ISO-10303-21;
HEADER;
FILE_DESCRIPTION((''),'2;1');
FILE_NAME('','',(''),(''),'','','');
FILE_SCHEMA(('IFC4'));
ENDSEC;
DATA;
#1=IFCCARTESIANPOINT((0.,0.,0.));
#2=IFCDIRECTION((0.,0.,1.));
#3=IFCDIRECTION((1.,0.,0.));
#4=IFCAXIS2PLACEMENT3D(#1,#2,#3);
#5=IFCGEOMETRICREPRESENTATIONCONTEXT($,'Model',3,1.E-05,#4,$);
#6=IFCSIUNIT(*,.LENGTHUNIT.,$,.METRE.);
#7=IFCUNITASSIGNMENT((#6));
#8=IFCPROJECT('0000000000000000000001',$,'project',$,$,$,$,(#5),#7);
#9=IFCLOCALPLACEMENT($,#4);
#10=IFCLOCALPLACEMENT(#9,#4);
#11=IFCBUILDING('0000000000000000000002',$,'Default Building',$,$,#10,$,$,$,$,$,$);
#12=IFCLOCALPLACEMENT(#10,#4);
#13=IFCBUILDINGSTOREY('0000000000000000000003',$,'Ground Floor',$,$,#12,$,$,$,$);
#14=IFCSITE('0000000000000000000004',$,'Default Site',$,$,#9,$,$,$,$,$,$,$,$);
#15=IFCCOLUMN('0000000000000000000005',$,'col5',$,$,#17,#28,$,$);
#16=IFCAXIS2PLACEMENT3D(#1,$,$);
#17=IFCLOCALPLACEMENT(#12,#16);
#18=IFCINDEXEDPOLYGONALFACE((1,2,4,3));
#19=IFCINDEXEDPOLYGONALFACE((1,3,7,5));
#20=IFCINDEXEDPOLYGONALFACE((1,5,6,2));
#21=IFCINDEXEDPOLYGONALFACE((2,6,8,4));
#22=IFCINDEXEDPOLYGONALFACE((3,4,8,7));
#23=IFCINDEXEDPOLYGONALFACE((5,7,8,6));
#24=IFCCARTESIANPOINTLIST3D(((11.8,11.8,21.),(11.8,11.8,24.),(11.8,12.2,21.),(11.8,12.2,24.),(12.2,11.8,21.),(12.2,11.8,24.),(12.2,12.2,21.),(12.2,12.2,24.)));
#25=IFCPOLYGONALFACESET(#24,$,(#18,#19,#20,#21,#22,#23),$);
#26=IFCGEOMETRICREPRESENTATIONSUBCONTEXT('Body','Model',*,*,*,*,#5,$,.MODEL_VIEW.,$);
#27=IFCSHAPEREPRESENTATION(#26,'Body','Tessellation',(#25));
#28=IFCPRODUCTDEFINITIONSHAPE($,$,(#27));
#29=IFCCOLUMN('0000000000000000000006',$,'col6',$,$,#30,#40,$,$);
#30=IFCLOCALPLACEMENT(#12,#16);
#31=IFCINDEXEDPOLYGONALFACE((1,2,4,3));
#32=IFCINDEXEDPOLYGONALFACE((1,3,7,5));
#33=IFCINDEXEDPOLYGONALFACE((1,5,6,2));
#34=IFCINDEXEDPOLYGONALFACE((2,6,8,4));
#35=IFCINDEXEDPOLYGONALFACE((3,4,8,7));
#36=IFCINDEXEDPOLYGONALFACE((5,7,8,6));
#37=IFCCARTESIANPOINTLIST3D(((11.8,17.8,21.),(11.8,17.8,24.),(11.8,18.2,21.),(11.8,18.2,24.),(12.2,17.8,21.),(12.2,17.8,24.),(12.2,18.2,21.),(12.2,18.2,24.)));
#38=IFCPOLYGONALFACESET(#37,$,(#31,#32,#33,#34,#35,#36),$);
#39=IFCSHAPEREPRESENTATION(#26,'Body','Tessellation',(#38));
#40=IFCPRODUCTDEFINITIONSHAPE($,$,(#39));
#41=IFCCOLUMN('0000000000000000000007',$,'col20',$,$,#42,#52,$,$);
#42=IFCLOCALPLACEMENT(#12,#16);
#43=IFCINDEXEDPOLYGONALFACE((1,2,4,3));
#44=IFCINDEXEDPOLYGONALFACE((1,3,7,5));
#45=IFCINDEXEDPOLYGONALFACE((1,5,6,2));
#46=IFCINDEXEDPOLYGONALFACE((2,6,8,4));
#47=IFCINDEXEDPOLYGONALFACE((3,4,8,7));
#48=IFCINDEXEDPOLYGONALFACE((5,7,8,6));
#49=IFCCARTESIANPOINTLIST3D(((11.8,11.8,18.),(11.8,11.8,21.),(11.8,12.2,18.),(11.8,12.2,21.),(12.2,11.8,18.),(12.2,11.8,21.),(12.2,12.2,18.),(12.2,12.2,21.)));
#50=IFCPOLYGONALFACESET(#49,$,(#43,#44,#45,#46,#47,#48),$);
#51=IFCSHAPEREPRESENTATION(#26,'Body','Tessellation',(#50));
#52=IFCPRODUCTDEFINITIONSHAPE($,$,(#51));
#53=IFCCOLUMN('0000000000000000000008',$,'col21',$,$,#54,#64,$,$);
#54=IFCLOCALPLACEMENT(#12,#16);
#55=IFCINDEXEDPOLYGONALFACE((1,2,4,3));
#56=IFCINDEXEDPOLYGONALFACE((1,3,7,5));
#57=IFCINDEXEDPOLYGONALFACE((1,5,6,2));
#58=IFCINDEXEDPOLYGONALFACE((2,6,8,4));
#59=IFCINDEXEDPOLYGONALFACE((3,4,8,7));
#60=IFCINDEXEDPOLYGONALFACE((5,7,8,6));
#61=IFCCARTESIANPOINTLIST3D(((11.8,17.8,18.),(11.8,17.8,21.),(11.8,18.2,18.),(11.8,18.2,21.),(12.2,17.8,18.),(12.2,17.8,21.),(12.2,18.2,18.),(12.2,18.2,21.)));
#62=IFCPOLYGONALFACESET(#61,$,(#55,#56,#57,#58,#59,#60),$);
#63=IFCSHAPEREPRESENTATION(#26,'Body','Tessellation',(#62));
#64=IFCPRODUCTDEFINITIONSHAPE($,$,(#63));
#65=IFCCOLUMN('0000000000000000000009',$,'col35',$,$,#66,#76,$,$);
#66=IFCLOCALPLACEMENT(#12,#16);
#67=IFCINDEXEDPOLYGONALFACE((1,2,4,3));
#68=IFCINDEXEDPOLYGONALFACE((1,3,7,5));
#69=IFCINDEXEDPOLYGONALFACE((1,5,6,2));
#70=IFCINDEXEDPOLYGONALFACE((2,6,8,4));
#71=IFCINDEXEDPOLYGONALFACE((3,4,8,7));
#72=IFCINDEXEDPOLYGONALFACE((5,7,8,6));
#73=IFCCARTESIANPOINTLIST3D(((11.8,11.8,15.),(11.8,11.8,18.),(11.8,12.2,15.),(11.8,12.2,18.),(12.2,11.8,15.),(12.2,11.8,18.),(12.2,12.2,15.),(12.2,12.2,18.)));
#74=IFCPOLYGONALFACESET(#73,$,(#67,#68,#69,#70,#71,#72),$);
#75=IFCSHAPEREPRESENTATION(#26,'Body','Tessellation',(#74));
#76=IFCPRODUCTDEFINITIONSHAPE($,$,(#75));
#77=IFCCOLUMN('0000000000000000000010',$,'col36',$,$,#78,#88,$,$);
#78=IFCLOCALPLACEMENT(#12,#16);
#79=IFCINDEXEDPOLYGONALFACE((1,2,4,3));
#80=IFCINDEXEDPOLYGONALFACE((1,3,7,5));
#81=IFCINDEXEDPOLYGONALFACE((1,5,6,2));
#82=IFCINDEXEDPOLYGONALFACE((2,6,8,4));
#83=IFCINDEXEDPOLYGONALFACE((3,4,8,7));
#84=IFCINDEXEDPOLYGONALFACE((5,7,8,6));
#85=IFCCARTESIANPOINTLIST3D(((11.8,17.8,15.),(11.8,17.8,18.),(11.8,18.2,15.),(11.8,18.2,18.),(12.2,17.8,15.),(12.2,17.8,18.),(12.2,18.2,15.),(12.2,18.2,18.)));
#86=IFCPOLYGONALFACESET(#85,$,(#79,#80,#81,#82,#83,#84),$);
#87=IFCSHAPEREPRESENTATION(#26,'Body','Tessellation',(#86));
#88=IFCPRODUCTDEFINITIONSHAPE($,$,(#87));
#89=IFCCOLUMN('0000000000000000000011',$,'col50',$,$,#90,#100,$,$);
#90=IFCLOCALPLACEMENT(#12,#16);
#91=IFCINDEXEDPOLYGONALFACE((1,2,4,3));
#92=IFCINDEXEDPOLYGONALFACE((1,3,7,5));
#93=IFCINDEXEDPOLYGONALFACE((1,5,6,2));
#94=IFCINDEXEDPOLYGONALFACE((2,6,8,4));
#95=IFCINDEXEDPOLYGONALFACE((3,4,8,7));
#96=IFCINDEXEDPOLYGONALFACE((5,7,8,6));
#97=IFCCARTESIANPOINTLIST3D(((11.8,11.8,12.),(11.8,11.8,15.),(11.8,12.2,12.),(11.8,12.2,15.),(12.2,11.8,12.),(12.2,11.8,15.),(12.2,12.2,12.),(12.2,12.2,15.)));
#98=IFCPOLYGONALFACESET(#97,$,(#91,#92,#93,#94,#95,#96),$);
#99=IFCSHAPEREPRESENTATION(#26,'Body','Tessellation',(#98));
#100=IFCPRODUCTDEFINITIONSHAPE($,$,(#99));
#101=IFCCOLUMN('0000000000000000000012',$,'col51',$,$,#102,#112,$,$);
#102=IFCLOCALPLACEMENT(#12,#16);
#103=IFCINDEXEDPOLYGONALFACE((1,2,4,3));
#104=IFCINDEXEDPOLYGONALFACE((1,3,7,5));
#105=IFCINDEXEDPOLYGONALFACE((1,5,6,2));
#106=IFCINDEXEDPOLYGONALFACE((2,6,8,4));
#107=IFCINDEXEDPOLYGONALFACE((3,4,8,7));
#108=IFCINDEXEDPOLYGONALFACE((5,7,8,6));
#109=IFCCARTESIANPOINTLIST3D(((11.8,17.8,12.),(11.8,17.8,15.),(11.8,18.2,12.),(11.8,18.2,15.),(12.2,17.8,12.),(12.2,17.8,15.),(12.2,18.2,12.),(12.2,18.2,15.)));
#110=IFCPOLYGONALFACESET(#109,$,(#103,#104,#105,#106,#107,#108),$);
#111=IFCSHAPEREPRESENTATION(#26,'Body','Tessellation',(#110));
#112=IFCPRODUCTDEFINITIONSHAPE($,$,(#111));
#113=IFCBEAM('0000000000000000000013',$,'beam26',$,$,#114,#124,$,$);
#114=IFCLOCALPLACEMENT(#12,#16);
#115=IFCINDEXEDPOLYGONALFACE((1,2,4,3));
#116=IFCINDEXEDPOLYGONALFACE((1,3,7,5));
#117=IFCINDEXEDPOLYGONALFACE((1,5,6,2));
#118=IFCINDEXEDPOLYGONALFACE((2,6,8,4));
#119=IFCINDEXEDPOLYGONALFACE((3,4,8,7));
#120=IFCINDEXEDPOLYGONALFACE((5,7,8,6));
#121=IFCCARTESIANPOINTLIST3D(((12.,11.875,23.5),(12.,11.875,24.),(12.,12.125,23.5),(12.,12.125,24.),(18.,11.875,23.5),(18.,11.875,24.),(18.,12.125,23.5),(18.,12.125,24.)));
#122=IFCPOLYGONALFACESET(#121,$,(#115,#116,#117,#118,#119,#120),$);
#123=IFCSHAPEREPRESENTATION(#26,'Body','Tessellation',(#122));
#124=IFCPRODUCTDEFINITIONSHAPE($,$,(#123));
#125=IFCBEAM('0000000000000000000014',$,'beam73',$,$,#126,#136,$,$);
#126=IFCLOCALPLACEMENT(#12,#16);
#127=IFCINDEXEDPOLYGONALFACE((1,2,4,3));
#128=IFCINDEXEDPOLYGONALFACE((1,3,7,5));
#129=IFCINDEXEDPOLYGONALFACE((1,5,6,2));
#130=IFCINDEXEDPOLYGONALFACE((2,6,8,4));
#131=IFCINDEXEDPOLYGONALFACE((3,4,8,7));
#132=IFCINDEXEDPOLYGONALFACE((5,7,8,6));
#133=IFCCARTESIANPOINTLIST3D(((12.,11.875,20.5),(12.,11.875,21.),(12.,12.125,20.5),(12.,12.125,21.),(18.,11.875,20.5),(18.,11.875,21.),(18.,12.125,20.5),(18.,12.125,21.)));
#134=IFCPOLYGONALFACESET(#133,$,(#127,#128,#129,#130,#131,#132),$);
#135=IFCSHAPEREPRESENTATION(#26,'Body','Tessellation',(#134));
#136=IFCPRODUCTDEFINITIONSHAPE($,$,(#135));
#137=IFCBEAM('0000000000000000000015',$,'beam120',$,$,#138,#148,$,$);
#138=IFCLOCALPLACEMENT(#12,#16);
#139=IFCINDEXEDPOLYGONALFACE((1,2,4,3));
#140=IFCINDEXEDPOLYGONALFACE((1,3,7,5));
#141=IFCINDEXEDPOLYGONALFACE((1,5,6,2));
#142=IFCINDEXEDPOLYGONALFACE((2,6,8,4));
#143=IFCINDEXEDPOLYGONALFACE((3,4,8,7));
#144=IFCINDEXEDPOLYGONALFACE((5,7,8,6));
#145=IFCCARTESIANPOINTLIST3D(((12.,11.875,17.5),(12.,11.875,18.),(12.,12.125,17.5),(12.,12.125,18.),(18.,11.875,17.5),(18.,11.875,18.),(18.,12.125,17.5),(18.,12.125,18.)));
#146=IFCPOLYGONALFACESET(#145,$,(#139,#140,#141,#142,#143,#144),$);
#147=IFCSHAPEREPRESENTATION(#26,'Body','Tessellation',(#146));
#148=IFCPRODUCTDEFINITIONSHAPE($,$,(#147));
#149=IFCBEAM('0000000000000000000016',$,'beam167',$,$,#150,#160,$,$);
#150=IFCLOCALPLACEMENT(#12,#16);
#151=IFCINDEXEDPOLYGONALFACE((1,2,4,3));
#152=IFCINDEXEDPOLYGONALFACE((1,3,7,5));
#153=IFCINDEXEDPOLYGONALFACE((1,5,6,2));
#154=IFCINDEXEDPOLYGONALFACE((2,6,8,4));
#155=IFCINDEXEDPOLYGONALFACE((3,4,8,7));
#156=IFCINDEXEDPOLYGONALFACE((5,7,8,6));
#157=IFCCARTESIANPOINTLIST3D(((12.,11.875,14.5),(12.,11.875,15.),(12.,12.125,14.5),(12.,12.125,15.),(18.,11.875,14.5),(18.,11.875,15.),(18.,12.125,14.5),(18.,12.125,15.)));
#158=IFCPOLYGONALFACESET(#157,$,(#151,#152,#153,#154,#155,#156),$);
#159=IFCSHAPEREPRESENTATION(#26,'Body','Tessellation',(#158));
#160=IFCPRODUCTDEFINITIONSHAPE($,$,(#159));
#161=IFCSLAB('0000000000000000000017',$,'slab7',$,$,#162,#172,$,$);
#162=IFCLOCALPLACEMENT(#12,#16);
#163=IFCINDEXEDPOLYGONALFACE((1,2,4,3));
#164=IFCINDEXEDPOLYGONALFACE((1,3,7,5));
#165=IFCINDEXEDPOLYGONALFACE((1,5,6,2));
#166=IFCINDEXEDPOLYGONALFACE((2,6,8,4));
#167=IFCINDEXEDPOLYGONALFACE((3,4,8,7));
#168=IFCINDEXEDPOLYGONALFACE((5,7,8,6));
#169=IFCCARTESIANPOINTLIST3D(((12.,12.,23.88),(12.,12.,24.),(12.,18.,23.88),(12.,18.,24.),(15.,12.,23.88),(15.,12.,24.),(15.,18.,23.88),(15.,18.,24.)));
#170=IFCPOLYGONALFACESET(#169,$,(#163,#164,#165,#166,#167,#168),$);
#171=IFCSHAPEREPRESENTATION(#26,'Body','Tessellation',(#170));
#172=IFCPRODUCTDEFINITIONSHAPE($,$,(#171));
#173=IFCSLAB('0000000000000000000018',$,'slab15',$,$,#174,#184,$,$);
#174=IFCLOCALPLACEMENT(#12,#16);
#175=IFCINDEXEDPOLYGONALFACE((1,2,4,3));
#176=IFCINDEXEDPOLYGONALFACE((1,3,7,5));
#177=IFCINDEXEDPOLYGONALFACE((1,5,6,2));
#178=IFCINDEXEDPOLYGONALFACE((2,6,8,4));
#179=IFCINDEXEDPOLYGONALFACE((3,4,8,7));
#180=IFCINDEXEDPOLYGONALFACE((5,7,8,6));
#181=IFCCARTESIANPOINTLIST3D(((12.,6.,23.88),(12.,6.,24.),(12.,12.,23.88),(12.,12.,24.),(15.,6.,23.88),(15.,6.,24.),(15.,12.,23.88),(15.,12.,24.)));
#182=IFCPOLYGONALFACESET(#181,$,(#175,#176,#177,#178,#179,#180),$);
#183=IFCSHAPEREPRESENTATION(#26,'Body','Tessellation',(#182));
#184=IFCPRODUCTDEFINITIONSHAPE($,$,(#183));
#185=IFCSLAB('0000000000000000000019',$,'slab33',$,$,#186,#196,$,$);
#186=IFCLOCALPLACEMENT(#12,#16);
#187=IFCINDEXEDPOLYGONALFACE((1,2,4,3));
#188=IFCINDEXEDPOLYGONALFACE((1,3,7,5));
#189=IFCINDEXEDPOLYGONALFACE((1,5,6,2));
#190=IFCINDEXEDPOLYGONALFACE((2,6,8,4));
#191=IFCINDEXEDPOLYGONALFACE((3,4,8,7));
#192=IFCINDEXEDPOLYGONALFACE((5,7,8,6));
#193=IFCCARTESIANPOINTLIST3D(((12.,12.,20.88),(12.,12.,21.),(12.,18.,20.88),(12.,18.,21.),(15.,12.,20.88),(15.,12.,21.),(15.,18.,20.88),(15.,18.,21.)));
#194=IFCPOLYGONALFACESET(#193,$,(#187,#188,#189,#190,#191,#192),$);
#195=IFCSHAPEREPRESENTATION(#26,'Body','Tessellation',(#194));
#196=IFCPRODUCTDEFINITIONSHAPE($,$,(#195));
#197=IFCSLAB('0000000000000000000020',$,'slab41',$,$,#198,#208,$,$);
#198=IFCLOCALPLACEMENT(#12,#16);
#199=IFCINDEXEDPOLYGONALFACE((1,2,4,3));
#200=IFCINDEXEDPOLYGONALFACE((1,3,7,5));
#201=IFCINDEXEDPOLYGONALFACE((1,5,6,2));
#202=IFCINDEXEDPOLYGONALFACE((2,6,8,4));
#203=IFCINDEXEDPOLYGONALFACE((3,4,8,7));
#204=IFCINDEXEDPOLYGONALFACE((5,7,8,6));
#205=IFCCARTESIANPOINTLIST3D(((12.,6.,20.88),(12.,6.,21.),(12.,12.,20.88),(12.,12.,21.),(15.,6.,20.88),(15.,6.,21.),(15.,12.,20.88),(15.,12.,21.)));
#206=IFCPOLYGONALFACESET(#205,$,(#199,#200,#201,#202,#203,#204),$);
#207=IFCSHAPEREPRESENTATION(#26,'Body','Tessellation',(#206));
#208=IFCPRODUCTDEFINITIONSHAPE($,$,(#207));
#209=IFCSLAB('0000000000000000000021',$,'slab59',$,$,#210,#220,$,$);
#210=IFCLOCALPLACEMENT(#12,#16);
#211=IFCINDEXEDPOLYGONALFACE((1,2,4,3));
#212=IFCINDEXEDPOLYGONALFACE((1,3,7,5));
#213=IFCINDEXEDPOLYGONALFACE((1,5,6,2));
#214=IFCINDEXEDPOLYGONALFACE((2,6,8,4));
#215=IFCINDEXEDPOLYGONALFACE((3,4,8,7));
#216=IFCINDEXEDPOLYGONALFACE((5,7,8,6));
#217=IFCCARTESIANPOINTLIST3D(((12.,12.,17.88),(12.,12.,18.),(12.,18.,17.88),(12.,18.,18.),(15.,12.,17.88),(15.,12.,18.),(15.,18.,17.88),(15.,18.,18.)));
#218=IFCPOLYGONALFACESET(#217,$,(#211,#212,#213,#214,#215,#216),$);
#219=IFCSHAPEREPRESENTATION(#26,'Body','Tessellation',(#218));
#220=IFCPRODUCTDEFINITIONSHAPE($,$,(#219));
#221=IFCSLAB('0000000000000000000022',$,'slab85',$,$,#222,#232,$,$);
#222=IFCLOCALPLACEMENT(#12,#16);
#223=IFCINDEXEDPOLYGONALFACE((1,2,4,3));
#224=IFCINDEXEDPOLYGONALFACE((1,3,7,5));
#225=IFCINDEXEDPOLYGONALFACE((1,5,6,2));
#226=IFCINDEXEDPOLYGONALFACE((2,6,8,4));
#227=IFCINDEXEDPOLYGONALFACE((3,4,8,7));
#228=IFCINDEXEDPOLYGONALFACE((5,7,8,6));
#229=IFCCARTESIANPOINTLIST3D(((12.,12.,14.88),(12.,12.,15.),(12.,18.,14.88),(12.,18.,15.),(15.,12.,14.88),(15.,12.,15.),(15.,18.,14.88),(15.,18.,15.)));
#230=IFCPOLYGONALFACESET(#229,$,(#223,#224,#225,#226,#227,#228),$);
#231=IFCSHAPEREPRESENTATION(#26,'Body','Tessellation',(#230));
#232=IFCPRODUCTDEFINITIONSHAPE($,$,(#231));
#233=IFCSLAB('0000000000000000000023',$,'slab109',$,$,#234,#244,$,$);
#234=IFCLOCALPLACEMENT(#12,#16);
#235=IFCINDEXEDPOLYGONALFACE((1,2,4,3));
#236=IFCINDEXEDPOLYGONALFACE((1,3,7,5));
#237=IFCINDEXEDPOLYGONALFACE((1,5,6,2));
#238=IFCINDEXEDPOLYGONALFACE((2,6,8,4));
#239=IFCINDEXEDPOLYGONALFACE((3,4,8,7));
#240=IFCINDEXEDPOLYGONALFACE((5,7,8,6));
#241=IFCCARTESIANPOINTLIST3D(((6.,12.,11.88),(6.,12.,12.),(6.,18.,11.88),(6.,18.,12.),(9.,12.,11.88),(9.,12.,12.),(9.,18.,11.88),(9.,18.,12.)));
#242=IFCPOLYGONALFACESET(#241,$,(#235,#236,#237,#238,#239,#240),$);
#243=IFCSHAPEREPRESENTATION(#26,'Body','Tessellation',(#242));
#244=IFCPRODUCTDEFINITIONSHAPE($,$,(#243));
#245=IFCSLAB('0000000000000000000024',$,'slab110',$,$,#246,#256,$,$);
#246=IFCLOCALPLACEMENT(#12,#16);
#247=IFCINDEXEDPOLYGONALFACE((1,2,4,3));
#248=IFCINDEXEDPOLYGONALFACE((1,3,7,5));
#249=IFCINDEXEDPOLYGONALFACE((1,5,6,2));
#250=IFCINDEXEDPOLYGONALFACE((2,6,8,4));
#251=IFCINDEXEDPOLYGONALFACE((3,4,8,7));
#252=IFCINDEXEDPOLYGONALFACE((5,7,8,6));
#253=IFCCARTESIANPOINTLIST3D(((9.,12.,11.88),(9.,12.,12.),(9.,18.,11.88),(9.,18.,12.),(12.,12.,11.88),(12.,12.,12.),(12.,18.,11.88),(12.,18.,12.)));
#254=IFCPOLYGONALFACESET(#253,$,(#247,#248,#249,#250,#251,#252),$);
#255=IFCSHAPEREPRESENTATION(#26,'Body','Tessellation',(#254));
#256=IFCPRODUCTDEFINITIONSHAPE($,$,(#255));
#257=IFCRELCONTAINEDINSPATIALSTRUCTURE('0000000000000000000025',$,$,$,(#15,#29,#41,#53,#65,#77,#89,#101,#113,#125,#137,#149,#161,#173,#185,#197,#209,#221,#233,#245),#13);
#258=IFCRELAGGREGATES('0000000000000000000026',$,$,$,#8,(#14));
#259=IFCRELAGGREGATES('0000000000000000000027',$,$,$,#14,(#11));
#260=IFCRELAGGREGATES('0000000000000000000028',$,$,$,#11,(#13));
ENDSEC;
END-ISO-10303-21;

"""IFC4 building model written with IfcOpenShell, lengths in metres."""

from ifc_helpers import new_model, si_unit, frame, origin_with_axes, place, context, subcontext, project, spatial, indexed_curve, outline, extrude, element, save


model = new_model("IFC4")

# Units and contexts
model_context = context("Model", 3, precision=1e-05, world=origin_with_axes())
body_context = subcontext(model_context, "Body", "Model", "MODEL_VIEW")
ifc_project = project(units=[si_unit("LENGTHUNIT", "METRE")], contexts=[model_context])

# Site, building, storey
site_placement = place(None, origin_with_axes())
site = spatial("IfcSite", under=ifc_project, at=site_placement, Name="Default Site")
building_placement = place(site_placement, origin_with_axes())
building = spatial("IfcBuilding", under=site, at=building_placement, Name="Default Building")
storey_placement = place(building_placement, origin_with_axes())
storey = spatial("IfcBuildingStorey", under=building, at=storey_placement, Name="Ground Floor")

# Columns
for number, where, z_axis, x_axis, name in (
    (1, (11.8, 11.8, 21.0), (0.0, 0.0, 1.0), (1.0, 0.0, 0.0), "col5"),
    (2, (11.8, 17.8, 21.0), (0.0, 0.0, 1.0), (1.0, 0.0, 0.0), "col6"),
    (3, (11.8, 11.8, 18.0), (0.0, 0.0, 1.0), (1.0, 0.0, 0.0), "col20"),
    (4, (11.8, 17.8, 18.0), (0.0, 0.0, 1.0), (1.0, 0.0, 0.0), "col21"),
    (5, (11.8, 11.8, 15.0), (0.0, 0.0, 1.0), (1.0, 0.0, 0.0), "col35"),
    (6, (11.8, 17.8, 15.0), (0.0, 0.0, 1.0), (1.0, 0.0, 0.0), "col36"),
    (7, (11.8, 11.8, 12.0), (0.0, 0.0, 1.0), (1.0, 0.0, 0.0), "col50"),
    (8, (11.8, 17.8, 12.0), (0.0, 0.0, 1.0), (1.0, 0.0, 0.0), "col51"),
):
    element("IfcColumn", number, at=place(storey_placement, frame(where, z_axis=z_axis, x_axis=x_axis)), inside=storey, Name=name, context=body_context, shape_type="SweptSolid", body=[
        extrude(outline(indexed_curve([(0.0, 0.0), (0.0, 0.4), (0.4, 0.4), (0.4, 0.0), (0.0, 0.0)], self_intersect=False)), origin_with_axes(), (0.0, 0.0, 1.0), 3.0),
    ])

# Beams
for number, where, z_axis, x_axis, name in (
    (9, (12.0, 11.875, 23.5), (0.0, 0.0, 1.0), (1.0, 0.0, 0.0), "beam26"),
    (10, (12.0, 11.875, 20.5), (0.0, 0.0, 1.0), (1.0, 0.0, 0.0), "beam73"),
    (11, (12.0, 11.875, 17.5), (0.0, 0.0, 1.0), (1.0, 0.0, 0.0), "beam120"),
    (12, (12.0, 11.875, 14.5), (0.0, 0.0, 1.0), (1.0, 0.0, 0.0), "beam167"),
):
    element("IfcBeam", number, at=place(storey_placement, frame(where, z_axis=z_axis, x_axis=x_axis)), inside=storey, Name=name, context=body_context, shape_type="SweptSolid", body=[
        extrude(outline(indexed_curve([(0.0, 0.0), (0.0, 0.25), (6.0, 0.25), (6.0, 0.0), (0.0, 0.0)], self_intersect=False)), origin_with_axes(), (0.0, 0.0, 1.0), 0.5),
    ])

# Slabs
for number, where, z_axis, x_axis, name in (
    (13, (12.0, 12.0, 23.88), (0.0, 0.0, 1.0), (1.0, 0.0, 0.0), "slab7"),
    (14, (12.0, 6.0, 23.88), (0.0, 0.0, 1.0), (1.0, 0.0, 0.0), "slab15"),
    (15, (12.0, 12.0, 20.88), (0.0, 0.0, 1.0), (1.0, 0.0, 0.0), "slab33"),
    (16, (12.0, 6.0, 20.88), (0.0, 0.0, 1.0), (1.0, 0.0, 0.0), "slab41"),
    (17, (12.0, 12.0, 17.88), (0.0, 0.0, 1.0), (1.0, 0.0, 0.0), "slab59"),
    (18, (12.0, 12.0, 14.88), (0.0, 0.0, 1.0), (1.0, 0.0, 0.0), "slab85"),
    (19, (6.0, 12.0, 11.88), (0.0, 0.0, 1.0), (1.0, 0.0, 0.0), "slab109"),
    (20, (9.0, 12.0, 11.88), (0.0, 0.0, 1.0), (1.0, 0.0, 0.0), "slab110"),
):
    element("IfcSlab", number, at=place(storey_placement, frame(where, z_axis=z_axis, x_axis=x_axis)), inside=storey, Name=name, context=body_context, shape_type="SweptSolid", body=[
        extrude(outline(indexed_curve([(0.0, 0.0), (0.0, 6.0), (3.0, 6.0), (3.0, 0.0), (0.0, 0.0)], self_intersect=False)), origin_with_axes(), (0.0, 0.0, 1.0), 0.12),
    ])

save(model, "model.ifc")
